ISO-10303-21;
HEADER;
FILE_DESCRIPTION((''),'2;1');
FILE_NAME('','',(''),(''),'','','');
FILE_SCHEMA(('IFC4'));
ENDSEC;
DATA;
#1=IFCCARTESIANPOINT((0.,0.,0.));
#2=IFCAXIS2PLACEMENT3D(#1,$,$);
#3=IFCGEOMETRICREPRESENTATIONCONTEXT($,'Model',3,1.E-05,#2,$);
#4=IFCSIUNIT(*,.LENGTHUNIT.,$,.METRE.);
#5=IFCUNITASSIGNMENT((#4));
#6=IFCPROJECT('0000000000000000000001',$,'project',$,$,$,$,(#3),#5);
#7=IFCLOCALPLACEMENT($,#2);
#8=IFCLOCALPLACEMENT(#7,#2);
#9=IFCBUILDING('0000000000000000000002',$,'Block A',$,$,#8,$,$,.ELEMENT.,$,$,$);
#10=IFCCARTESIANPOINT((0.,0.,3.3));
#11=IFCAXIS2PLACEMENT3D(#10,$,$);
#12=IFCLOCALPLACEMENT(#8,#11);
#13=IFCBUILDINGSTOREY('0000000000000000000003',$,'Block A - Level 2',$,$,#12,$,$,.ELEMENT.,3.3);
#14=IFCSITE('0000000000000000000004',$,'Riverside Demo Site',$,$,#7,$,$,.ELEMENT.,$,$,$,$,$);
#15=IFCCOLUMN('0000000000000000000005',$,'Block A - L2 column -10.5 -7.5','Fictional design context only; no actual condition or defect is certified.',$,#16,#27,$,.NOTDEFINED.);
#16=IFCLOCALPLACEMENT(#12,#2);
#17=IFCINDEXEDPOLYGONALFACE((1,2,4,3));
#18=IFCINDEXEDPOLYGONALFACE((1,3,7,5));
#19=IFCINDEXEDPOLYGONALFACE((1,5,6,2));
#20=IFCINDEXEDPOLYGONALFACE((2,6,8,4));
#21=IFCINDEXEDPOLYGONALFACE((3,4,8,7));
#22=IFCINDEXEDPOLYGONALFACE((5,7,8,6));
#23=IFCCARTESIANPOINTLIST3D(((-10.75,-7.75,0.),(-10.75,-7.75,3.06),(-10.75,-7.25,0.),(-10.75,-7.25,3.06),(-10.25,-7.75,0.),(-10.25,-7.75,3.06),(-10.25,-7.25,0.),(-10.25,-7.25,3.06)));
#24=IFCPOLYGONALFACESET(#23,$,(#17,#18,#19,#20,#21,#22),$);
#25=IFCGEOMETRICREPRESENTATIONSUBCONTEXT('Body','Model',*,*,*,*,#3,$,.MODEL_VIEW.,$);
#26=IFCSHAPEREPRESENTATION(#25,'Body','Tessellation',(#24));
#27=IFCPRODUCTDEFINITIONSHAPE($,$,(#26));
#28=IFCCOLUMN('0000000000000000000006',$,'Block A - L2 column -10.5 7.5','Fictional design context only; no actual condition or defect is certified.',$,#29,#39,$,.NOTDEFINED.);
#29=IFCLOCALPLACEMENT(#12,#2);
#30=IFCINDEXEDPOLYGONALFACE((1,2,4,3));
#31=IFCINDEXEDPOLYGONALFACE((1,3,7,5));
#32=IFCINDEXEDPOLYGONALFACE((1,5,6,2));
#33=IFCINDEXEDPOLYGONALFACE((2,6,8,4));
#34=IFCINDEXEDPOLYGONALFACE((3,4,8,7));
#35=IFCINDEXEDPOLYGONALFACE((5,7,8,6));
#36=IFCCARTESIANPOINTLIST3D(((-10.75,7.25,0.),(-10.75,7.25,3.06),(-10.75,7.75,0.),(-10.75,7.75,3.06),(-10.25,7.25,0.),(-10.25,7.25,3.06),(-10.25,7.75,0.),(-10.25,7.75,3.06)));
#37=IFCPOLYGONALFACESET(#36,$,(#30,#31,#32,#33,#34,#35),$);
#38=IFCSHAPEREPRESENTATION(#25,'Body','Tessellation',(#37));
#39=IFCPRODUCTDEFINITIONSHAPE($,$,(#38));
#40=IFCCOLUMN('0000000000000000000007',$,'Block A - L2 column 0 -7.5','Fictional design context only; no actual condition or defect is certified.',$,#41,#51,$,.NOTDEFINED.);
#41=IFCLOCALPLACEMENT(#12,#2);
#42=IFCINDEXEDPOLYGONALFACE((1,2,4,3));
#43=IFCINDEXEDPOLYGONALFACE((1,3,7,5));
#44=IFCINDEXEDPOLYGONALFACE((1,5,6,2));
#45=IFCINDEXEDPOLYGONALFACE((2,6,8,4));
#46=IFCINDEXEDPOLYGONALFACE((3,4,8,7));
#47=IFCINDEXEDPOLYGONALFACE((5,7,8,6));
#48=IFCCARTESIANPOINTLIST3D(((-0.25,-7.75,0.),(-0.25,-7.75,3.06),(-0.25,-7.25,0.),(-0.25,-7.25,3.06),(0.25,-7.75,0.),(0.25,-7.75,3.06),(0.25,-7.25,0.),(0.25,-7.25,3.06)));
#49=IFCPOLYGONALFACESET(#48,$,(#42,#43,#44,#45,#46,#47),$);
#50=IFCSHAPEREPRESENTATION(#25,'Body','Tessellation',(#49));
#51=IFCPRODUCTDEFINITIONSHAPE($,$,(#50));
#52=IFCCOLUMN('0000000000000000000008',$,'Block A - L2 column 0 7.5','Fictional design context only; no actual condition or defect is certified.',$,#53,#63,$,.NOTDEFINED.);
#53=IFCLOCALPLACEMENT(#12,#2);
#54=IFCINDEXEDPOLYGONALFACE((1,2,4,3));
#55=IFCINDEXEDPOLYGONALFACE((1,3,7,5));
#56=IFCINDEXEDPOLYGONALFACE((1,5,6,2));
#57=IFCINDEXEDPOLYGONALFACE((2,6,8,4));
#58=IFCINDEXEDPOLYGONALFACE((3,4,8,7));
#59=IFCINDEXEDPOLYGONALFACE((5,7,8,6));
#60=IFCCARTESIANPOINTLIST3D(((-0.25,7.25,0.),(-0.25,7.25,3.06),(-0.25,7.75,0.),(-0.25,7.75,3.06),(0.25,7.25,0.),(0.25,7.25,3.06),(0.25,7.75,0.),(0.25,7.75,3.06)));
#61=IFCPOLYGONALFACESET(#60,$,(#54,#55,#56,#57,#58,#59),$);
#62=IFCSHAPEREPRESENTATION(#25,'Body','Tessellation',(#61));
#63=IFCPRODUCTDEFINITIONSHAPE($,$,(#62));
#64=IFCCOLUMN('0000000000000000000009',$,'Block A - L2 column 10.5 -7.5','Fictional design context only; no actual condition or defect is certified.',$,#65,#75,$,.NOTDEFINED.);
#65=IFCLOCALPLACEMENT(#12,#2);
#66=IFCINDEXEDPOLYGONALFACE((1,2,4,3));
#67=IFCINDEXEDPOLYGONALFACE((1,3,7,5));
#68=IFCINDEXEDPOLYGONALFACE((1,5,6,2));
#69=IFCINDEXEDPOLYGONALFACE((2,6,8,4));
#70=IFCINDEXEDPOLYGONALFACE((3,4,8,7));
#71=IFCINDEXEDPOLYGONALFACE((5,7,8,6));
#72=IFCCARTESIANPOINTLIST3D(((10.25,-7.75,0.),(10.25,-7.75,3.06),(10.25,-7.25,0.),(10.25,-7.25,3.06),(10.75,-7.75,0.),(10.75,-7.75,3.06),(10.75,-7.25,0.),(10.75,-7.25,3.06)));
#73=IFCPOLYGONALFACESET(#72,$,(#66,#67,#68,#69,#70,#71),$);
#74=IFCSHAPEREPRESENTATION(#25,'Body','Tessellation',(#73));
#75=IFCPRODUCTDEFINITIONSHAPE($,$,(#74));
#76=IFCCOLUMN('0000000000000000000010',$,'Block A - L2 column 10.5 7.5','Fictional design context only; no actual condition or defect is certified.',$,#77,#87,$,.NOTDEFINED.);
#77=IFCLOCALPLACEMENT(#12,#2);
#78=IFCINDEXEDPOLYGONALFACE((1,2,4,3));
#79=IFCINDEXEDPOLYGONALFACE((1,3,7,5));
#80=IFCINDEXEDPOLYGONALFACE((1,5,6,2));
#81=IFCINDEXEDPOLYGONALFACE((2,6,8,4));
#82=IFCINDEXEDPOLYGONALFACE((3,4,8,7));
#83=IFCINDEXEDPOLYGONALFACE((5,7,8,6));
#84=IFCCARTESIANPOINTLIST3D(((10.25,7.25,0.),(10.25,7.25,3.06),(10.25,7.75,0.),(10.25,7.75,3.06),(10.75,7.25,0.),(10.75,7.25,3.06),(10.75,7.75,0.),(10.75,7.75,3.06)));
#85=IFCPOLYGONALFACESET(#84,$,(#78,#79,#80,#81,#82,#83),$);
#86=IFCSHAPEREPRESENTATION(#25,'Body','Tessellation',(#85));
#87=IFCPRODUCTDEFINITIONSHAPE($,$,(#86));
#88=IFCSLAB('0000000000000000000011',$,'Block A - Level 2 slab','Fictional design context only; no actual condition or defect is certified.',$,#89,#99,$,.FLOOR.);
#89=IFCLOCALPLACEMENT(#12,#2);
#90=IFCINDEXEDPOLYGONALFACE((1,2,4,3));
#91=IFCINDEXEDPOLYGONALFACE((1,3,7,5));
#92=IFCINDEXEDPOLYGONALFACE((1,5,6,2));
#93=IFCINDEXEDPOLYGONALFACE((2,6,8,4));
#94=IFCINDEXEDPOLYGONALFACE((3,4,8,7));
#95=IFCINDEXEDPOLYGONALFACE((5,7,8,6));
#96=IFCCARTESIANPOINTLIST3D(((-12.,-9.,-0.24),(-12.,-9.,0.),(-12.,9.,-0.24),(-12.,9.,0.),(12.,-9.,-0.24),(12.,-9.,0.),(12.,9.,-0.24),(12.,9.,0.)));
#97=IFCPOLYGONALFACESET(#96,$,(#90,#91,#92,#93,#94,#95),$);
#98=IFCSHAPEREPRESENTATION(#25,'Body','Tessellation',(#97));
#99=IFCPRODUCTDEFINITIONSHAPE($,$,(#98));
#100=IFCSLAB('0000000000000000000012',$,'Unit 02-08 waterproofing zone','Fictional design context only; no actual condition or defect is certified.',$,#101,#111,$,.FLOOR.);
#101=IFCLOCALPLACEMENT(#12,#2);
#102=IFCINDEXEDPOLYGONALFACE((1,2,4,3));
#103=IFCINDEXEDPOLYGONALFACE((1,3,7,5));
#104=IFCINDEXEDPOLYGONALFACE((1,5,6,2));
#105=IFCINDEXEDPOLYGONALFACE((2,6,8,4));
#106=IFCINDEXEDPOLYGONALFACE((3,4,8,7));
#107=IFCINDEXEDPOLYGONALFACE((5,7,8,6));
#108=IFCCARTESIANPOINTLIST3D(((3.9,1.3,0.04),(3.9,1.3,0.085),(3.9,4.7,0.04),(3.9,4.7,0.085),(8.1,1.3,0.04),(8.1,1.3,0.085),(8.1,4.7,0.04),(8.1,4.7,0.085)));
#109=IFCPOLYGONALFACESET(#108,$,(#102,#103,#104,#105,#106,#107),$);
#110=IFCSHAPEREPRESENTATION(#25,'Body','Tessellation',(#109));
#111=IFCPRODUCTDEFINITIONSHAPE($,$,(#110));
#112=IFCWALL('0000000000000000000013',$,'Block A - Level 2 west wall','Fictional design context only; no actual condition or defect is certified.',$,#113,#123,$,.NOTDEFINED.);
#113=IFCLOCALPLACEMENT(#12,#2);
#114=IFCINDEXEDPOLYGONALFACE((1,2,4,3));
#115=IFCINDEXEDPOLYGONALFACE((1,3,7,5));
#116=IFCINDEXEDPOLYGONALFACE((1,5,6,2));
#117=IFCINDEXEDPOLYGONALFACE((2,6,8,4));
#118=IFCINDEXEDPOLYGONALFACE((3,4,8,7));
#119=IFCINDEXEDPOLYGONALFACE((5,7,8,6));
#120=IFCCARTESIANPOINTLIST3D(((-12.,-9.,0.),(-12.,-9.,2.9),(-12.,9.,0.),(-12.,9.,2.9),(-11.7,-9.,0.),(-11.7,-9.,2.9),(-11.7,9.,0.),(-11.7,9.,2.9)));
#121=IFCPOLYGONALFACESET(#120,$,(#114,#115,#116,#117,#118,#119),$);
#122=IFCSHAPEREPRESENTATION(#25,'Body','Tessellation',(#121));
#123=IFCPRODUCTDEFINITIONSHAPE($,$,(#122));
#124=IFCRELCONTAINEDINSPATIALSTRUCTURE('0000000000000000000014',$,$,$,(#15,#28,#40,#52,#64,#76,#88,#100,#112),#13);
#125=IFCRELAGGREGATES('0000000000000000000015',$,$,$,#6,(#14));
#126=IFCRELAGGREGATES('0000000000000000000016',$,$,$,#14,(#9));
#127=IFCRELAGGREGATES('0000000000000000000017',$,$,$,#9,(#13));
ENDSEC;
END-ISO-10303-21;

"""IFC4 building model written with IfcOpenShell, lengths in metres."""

from ifc_helpers import new_model, si_unit, frame, origin, origin_2d, place, context, subcontext, project, spatial, rectangle, extrude, element, save


model = new_model("IFC4")

# Units and contexts
model_context = context("Model", 3, precision=1e-05, world=origin())
body_context = subcontext(model_context, "Body", "Model", "MODEL_VIEW")
ifc_project = project(units=[si_unit("LENGTHUNIT", "METRE")], contexts=[model_context])

# Site, building, storey
site_placement = place(None, origin())
site = spatial("IfcSite", under=ifc_project, at=site_placement, Name="Riverside Demo Site", CompositionType="ELEMENT")
building_placement = place(site_placement, origin())
building = spatial("IfcBuilding", under=site, at=building_placement, Name="Block A", CompositionType="ELEMENT")
storey_placement = place(building_placement, frame((0.0, 0.0, 3.3)))
storey = spatial("IfcBuildingStorey", under=building, at=storey_placement, Name="Block A - Level 2", CompositionType="ELEMENT", Elevation=3.3)

# Columns
for number, where, name in (
    (1, (-10.5, -7.5, 0.0), "Block A - L2 column -10.5 -7.5"),
    (2, (-10.5, 7.5, 0.0), "Block A - L2 column -10.5 7.5"),
    (3, (0.0, -7.5, 0.0), "Block A - L2 column 0 -7.5"),
    (4, (0.0, 7.5, 0.0), "Block A - L2 column 0 7.5"),
    (5, (10.5, -7.5, 0.0), "Block A - L2 column 10.5 -7.5"),
    (6, (10.5, 7.5, 0.0), "Block A - L2 column 10.5 7.5"),
):
    element("IfcColumn", number, at=place(storey_placement, frame(where)), inside=storey, Name=name, Description="Fictional design context only; no actual condition or defect is certified.", PredefinedType="NOTDEFINED", context=body_context, shape_type="SweptSolid", body=[
        extrude(rectangle(XDim=0.5, YDim=0.5, at=origin_2d()), origin(), (0.0, 0.0, 1.0), 3.06),
    ])

# Slabs
slab_1_placement = place(storey_placement, frame((0.0, 0.0, -0.24)))
element("IfcSlab", 7, at=slab_1_placement, inside=storey, Name="Block A - Level 2 slab", Description="Fictional design context only; no actual condition or defect is certified.", PredefinedType="FLOOR", context=body_context, shape_type="SweptSolid", body=[
    extrude(rectangle(XDim=24.0, YDim=18.0, at=origin_2d()), origin(), (0.0, 0.0, 1.0), 0.24),
])
slab_2_placement = place(storey_placement, frame((6.0, 3.0, 0.04)))
element("IfcSlab", 8, at=slab_2_placement, inside=storey, Name="Unit 02-08 waterproofing zone", Description="Fictional design context only; no actual condition or defect is certified.", PredefinedType="FLOOR", context=body_context, shape_type="SweptSolid", body=[
    extrude(rectangle(XDim=4.2, YDim=3.4, at=origin_2d()), origin(), (0.0, 0.0, 1.0), 0.045),
])

# Wall
wall_placement = place(storey_placement, frame((-11.85, 0.0, 0.0)))
element("IfcWall", 9, at=wall_placement, inside=storey, Name="Block A - Level 2 west wall", Description="Fictional design context only; no actual condition or defect is certified.", PredefinedType="NOTDEFINED", context=body_context, shape_type="SweptSolid", body=[
    extrude(rectangle(XDim=0.3, YDim=18.0, at=origin_2d()), origin(), (0.0, 0.0, 1.0), 2.9),
])

save(model, "model.ifc")
